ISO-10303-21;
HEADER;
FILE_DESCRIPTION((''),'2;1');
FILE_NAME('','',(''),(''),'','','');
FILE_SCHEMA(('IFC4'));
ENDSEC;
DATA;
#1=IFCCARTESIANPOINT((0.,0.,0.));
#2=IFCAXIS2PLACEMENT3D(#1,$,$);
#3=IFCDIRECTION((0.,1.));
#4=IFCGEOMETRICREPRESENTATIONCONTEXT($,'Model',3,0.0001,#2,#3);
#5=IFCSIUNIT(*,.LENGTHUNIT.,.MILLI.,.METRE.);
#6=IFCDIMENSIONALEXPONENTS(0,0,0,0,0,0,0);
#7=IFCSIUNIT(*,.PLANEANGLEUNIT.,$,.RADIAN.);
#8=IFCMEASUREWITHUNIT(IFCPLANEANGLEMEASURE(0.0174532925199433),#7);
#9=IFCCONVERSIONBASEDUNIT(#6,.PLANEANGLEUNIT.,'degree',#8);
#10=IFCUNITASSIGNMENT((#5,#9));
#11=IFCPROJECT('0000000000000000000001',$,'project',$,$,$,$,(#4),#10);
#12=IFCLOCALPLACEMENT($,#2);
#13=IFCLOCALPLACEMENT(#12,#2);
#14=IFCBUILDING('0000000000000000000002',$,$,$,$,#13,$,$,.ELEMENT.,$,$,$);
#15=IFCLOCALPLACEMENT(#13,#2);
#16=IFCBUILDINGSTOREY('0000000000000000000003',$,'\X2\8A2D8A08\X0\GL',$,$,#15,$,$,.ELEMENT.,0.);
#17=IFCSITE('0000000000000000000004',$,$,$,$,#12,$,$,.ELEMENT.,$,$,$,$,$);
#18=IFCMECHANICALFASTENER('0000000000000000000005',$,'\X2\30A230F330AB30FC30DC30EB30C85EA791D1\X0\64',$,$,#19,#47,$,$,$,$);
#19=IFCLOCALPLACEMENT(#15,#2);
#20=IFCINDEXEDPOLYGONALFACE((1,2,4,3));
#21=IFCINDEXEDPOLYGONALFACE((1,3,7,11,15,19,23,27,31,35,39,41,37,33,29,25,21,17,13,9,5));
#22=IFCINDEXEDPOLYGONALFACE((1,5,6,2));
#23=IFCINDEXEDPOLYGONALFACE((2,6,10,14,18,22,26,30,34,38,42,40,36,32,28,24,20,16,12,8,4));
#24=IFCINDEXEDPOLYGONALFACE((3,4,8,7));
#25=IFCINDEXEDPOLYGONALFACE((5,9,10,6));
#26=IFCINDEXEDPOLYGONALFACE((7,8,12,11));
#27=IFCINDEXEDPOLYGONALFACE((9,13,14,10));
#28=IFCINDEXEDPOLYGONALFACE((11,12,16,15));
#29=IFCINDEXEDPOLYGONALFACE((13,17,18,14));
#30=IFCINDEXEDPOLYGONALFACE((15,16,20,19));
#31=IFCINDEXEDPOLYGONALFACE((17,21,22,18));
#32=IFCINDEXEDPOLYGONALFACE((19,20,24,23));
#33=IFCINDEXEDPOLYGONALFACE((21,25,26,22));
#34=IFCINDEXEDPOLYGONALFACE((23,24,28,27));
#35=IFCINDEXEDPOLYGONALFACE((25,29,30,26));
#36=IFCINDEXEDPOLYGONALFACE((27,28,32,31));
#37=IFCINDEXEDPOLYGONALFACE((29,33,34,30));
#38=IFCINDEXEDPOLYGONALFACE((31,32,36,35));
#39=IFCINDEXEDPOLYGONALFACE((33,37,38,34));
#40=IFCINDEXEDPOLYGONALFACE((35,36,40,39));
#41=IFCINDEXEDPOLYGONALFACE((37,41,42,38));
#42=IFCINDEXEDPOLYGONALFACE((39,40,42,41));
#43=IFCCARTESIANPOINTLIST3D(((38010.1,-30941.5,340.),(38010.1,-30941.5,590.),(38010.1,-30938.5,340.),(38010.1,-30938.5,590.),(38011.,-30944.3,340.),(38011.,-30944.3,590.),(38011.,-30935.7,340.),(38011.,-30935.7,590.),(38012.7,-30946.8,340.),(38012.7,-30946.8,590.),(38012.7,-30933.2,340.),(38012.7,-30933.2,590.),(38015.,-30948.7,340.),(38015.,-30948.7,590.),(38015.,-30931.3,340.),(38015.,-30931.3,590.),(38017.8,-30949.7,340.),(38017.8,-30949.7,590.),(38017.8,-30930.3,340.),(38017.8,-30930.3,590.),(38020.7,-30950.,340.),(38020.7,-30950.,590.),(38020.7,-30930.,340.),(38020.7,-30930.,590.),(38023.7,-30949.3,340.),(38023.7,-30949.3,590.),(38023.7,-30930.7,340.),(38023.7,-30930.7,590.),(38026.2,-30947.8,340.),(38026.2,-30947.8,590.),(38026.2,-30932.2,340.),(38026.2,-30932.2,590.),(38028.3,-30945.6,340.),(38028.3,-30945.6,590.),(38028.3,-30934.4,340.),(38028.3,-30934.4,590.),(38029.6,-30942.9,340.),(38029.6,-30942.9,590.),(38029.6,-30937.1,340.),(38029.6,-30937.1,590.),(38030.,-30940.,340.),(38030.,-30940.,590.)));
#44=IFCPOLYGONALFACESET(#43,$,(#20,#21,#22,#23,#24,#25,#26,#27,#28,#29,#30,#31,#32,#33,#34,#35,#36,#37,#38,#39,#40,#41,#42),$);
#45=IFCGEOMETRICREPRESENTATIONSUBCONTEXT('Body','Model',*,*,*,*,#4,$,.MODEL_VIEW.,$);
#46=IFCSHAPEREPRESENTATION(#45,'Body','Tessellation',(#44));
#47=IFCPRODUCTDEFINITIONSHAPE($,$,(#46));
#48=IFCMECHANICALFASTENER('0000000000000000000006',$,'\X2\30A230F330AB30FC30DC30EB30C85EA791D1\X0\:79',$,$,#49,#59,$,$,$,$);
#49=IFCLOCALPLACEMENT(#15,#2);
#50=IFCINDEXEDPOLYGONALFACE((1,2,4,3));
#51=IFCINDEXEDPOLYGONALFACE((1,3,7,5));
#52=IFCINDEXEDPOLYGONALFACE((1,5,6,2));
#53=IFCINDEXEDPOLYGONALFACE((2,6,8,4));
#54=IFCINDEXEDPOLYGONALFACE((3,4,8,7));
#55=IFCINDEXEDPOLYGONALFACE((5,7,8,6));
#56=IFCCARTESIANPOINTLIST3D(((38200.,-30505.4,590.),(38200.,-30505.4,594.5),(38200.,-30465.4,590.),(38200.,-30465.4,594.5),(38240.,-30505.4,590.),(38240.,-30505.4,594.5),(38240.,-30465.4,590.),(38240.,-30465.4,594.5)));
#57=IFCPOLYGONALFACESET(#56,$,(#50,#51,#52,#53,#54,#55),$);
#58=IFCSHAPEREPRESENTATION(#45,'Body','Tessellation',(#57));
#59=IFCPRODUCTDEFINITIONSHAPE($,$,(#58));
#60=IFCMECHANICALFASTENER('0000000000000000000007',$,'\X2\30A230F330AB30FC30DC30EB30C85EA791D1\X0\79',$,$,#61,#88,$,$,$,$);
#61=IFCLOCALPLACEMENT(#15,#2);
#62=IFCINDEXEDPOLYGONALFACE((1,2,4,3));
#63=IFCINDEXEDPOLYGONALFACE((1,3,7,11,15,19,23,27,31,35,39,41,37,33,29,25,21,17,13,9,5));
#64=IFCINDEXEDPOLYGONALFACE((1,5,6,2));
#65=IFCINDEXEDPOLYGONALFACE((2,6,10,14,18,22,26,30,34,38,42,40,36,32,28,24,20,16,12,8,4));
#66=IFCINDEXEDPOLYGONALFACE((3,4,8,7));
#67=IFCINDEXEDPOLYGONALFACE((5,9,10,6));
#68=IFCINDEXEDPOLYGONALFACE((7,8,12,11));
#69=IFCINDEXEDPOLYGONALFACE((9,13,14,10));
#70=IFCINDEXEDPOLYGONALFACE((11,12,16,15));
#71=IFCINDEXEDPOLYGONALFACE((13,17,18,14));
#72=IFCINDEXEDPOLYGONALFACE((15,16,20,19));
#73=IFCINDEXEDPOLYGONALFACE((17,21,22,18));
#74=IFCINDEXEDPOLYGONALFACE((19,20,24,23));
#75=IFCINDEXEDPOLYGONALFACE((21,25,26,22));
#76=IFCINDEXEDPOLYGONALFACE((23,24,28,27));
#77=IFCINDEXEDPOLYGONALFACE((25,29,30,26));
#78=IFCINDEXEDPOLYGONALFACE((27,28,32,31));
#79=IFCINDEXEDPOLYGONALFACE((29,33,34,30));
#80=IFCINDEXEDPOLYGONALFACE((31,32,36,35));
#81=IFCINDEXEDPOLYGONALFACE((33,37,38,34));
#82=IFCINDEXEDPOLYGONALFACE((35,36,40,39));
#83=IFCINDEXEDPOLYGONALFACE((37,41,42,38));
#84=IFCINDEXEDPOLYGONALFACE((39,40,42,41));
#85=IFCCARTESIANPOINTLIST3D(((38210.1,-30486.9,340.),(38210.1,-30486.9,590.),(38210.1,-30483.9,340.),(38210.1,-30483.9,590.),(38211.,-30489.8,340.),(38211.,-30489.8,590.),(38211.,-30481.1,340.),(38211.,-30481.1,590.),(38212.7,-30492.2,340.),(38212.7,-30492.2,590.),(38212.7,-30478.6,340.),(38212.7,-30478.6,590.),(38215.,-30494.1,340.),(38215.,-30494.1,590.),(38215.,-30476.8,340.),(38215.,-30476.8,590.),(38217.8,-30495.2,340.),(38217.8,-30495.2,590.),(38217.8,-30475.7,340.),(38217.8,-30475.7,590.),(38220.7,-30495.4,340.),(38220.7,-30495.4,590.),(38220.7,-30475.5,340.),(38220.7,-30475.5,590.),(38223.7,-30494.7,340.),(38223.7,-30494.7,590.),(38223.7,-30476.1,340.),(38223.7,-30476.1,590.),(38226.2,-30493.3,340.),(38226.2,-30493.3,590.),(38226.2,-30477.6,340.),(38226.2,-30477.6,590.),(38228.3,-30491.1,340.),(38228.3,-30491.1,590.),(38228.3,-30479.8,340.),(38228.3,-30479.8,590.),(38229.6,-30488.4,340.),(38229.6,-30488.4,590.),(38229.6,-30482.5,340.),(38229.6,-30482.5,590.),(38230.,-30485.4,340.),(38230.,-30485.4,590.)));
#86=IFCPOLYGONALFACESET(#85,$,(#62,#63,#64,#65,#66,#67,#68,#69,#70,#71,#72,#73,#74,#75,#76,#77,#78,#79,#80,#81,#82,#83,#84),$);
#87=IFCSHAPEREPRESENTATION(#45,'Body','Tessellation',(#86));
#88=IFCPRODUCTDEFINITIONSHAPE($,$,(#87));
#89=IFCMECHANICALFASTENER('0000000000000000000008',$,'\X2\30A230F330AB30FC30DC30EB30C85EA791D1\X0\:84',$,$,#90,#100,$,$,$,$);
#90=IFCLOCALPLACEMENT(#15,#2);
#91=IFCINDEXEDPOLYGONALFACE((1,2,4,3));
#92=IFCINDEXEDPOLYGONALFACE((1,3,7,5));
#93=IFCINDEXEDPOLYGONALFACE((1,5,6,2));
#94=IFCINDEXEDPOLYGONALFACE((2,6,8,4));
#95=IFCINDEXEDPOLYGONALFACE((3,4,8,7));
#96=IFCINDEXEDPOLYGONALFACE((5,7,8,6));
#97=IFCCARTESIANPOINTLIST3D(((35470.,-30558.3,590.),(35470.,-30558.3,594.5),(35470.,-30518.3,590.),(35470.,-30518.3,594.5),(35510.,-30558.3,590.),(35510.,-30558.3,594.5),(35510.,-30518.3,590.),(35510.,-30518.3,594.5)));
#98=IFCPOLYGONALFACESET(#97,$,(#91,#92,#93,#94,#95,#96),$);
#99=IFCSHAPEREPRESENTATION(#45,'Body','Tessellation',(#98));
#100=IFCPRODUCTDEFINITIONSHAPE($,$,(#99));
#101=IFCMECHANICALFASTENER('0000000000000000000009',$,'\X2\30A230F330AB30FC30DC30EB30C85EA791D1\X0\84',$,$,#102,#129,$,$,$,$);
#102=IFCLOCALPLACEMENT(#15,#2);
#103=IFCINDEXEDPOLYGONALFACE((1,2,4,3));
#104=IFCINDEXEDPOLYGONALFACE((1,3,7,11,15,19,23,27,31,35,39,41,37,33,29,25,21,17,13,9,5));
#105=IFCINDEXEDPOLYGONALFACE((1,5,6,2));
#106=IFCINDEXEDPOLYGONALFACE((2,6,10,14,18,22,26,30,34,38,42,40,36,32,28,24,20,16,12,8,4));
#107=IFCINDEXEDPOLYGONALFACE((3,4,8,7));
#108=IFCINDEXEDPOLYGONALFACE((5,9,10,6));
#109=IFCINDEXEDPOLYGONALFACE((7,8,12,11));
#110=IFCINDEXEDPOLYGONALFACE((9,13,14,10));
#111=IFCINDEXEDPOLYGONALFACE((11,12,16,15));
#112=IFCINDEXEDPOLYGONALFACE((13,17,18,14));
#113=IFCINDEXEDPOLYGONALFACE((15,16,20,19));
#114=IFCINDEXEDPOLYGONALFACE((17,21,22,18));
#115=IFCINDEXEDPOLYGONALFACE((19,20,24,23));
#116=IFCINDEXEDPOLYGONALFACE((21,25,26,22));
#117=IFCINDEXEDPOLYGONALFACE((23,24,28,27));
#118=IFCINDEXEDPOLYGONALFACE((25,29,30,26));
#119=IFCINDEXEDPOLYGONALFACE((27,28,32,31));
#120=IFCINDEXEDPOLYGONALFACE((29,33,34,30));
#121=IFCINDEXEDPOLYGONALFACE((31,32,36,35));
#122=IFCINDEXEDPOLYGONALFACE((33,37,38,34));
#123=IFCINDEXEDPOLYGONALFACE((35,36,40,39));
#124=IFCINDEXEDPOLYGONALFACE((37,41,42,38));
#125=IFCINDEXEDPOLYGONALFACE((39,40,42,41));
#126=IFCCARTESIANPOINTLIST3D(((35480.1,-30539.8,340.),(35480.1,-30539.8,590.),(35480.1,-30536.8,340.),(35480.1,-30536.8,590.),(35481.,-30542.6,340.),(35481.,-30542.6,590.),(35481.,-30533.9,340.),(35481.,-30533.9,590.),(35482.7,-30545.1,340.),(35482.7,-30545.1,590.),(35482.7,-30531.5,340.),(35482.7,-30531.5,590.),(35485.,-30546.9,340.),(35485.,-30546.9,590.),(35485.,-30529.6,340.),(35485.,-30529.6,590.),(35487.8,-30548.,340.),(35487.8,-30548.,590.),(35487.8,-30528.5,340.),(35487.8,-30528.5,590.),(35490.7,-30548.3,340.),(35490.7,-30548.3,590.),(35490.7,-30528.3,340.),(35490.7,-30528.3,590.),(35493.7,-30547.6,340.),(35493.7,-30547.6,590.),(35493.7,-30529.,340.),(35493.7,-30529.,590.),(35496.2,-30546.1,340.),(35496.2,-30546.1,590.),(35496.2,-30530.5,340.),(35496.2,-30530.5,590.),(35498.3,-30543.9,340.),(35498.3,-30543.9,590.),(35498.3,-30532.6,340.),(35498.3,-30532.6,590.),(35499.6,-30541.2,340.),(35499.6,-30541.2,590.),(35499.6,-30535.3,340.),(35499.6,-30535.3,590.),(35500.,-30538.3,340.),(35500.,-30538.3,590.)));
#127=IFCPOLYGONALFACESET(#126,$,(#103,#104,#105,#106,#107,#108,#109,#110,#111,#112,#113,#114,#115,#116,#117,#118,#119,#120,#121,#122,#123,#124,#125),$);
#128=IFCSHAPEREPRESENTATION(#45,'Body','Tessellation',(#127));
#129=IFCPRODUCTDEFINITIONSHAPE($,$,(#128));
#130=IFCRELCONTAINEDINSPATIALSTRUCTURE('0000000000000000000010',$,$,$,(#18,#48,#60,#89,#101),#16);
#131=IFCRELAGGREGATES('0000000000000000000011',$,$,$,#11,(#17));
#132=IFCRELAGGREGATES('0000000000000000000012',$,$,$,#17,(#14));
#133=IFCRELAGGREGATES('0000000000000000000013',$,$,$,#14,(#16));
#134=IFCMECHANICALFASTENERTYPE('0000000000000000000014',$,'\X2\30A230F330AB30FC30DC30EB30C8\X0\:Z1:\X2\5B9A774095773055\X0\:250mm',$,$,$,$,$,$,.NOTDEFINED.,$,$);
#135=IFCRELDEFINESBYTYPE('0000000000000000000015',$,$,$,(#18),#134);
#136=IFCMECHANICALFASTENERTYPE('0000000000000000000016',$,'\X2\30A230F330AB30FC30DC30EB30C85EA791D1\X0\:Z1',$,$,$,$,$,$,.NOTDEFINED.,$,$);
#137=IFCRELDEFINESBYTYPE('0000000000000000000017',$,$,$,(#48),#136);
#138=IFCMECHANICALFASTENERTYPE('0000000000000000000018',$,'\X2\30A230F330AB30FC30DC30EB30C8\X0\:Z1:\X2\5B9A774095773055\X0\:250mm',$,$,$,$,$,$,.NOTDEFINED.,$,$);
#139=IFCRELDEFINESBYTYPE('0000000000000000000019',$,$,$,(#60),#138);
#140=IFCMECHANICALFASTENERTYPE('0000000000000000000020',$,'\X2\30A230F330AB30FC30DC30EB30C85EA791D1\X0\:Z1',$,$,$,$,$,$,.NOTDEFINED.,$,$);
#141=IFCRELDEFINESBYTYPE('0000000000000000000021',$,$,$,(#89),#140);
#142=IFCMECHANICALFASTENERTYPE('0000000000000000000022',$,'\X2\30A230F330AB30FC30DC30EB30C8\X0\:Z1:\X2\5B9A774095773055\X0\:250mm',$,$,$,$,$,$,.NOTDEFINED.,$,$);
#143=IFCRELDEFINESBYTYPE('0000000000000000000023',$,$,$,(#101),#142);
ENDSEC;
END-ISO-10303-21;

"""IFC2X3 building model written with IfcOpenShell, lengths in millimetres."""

from ifc_helpers import new_model, entity, si_unit, converted_unit, direction, frame, origin, origin_with_axes, origin_2d, place, context, subcontext, project, spatial, rectangle, circle, extrude, type_object, element, save


model = new_model("IFC2X3")

# Units and contexts
model_context = context("Model", 3, precision=0.0001, world=origin(), true_north=direction((0.0, 1.0)))
body_context = subcontext(model_context, "Body", "Model", "MODEL_VIEW")
ifc_project = project(units=[si_unit("LENGTHUNIT", "METRE", prefix="MILLI"), converted_unit("PLANEANGLEUNIT", "degree", entity("IfcPlaneAngleMeasure", 0.0174532925199433), si_unit("PLANEANGLEUNIT", "RADIAN"), dimensions=[0, 0, 0, 0, 0, 0, 0])], contexts=[model_context])

# Site, building, storey
site_placement = place(None, origin())
site = spatial("IfcSite", under=ifc_project, at=site_placement, CompositionType="ELEMENT")
building_placement = place(site_placement, origin())
building = spatial("IfcBuilding", under=site, at=building_placement, CompositionType="ELEMENT")
storey_placement = place(building_placement, origin())
storey = spatial("IfcBuildingStorey", under=building, at=storey_placement, Name="設計GL", CompositionType="ELEMENT", Elevation=0.0)

# Mechanical fasteners
mechanical_fastener_type_1 = type_object("IfcMechanicalFastenerType", Name="アンカーボルト:Z1:定着長さ:250mm")
mechanical_fastener_1_placement = place(storey_placement, frame((38020.0, -30940.0, 340.0)))
element("IfcMechanicalFastener", 1, at=mechanical_fastener_1_placement, inside=storey, type_object=mechanical_fastener_type_1, Name="アンカーボルト座金64", context=body_context, shape_type="SweptSolid", body=[
    extrude(circle(Radius=10.0, at=origin_2d()), origin_with_axes(), (0.0, 0.0, 1.0), 250.0),
])
mechanical_fastener_type_2 = type_object("IfcMechanicalFastenerType", Name="アンカーボルト座金:Z1")
mechanical_fastener_2_placement = place(storey_placement, frame((38220.0, -30485.4, 590.0)))
element("IfcMechanicalFastener", 2, at=mechanical_fastener_2_placement, inside=storey, type_object=mechanical_fastener_type_2, Name="アンカーボルト座金:79", context=body_context, shape_type="SweptSolid", body=[
    extrude(rectangle(XDim=40.0, YDim=40.0, at=origin_2d()), origin_with_axes(), (0.0, 0.0, 1.0), 4.5),
])
mechanical_fastener_type_3 = type_object("IfcMechanicalFastenerType", Name="アンカーボルト:Z1:定着長さ:250mm")
mechanical_fastener_3_placement = place(storey_placement, frame((38220.0, -30485.4, 340.0)))
element("IfcMechanicalFastener", 3, at=mechanical_fastener_3_placement, inside=storey, type_object=mechanical_fastener_type_3, Name="アンカーボルト座金79", context=body_context, shape_type="SweptSolid", body=[
    extrude(circle(Radius=10.0, at=origin_2d()), origin_with_axes(), (0.0, 0.0, 1.0), 250.0),
])
mechanical_fastener_type_4 = type_object("IfcMechanicalFastenerType", Name="アンカーボルト座金:Z1")
mechanical_fastener_4_placement = place(storey_placement, frame((35490.0, -30538.3, 590.0)))
element("IfcMechanicalFastener", 4, at=mechanical_fastener_4_placement, inside=storey, type_object=mechanical_fastener_type_4, Name="アンカーボルト座金:84", context=body_context, shape_type="SweptSolid", body=[
    extrude(rectangle(XDim=40.0, YDim=40.0, at=origin_2d()), origin_with_axes(), (0.0, 0.0, 1.0), 4.5),
])
mechanical_fastener_type_5 = type_object("IfcMechanicalFastenerType", Name="アンカーボルト:Z1:定着長さ:250mm")
mechanical_fastener_5_placement = place(storey_placement, frame((35490.0, -30538.3, 340.0)))
element("IfcMechanicalFastener", 5, at=mechanical_fastener_5_placement, inside=storey, type_object=mechanical_fastener_type_5, Name="アンカーボルト座金84", context=body_context, shape_type="SweptSolid", body=[
    extrude(circle(Radius=10.0, at=origin_2d()), origin_with_axes(), (0.0, 0.0, 1.0), 250.0),
])

save(model, "model.ifc")
